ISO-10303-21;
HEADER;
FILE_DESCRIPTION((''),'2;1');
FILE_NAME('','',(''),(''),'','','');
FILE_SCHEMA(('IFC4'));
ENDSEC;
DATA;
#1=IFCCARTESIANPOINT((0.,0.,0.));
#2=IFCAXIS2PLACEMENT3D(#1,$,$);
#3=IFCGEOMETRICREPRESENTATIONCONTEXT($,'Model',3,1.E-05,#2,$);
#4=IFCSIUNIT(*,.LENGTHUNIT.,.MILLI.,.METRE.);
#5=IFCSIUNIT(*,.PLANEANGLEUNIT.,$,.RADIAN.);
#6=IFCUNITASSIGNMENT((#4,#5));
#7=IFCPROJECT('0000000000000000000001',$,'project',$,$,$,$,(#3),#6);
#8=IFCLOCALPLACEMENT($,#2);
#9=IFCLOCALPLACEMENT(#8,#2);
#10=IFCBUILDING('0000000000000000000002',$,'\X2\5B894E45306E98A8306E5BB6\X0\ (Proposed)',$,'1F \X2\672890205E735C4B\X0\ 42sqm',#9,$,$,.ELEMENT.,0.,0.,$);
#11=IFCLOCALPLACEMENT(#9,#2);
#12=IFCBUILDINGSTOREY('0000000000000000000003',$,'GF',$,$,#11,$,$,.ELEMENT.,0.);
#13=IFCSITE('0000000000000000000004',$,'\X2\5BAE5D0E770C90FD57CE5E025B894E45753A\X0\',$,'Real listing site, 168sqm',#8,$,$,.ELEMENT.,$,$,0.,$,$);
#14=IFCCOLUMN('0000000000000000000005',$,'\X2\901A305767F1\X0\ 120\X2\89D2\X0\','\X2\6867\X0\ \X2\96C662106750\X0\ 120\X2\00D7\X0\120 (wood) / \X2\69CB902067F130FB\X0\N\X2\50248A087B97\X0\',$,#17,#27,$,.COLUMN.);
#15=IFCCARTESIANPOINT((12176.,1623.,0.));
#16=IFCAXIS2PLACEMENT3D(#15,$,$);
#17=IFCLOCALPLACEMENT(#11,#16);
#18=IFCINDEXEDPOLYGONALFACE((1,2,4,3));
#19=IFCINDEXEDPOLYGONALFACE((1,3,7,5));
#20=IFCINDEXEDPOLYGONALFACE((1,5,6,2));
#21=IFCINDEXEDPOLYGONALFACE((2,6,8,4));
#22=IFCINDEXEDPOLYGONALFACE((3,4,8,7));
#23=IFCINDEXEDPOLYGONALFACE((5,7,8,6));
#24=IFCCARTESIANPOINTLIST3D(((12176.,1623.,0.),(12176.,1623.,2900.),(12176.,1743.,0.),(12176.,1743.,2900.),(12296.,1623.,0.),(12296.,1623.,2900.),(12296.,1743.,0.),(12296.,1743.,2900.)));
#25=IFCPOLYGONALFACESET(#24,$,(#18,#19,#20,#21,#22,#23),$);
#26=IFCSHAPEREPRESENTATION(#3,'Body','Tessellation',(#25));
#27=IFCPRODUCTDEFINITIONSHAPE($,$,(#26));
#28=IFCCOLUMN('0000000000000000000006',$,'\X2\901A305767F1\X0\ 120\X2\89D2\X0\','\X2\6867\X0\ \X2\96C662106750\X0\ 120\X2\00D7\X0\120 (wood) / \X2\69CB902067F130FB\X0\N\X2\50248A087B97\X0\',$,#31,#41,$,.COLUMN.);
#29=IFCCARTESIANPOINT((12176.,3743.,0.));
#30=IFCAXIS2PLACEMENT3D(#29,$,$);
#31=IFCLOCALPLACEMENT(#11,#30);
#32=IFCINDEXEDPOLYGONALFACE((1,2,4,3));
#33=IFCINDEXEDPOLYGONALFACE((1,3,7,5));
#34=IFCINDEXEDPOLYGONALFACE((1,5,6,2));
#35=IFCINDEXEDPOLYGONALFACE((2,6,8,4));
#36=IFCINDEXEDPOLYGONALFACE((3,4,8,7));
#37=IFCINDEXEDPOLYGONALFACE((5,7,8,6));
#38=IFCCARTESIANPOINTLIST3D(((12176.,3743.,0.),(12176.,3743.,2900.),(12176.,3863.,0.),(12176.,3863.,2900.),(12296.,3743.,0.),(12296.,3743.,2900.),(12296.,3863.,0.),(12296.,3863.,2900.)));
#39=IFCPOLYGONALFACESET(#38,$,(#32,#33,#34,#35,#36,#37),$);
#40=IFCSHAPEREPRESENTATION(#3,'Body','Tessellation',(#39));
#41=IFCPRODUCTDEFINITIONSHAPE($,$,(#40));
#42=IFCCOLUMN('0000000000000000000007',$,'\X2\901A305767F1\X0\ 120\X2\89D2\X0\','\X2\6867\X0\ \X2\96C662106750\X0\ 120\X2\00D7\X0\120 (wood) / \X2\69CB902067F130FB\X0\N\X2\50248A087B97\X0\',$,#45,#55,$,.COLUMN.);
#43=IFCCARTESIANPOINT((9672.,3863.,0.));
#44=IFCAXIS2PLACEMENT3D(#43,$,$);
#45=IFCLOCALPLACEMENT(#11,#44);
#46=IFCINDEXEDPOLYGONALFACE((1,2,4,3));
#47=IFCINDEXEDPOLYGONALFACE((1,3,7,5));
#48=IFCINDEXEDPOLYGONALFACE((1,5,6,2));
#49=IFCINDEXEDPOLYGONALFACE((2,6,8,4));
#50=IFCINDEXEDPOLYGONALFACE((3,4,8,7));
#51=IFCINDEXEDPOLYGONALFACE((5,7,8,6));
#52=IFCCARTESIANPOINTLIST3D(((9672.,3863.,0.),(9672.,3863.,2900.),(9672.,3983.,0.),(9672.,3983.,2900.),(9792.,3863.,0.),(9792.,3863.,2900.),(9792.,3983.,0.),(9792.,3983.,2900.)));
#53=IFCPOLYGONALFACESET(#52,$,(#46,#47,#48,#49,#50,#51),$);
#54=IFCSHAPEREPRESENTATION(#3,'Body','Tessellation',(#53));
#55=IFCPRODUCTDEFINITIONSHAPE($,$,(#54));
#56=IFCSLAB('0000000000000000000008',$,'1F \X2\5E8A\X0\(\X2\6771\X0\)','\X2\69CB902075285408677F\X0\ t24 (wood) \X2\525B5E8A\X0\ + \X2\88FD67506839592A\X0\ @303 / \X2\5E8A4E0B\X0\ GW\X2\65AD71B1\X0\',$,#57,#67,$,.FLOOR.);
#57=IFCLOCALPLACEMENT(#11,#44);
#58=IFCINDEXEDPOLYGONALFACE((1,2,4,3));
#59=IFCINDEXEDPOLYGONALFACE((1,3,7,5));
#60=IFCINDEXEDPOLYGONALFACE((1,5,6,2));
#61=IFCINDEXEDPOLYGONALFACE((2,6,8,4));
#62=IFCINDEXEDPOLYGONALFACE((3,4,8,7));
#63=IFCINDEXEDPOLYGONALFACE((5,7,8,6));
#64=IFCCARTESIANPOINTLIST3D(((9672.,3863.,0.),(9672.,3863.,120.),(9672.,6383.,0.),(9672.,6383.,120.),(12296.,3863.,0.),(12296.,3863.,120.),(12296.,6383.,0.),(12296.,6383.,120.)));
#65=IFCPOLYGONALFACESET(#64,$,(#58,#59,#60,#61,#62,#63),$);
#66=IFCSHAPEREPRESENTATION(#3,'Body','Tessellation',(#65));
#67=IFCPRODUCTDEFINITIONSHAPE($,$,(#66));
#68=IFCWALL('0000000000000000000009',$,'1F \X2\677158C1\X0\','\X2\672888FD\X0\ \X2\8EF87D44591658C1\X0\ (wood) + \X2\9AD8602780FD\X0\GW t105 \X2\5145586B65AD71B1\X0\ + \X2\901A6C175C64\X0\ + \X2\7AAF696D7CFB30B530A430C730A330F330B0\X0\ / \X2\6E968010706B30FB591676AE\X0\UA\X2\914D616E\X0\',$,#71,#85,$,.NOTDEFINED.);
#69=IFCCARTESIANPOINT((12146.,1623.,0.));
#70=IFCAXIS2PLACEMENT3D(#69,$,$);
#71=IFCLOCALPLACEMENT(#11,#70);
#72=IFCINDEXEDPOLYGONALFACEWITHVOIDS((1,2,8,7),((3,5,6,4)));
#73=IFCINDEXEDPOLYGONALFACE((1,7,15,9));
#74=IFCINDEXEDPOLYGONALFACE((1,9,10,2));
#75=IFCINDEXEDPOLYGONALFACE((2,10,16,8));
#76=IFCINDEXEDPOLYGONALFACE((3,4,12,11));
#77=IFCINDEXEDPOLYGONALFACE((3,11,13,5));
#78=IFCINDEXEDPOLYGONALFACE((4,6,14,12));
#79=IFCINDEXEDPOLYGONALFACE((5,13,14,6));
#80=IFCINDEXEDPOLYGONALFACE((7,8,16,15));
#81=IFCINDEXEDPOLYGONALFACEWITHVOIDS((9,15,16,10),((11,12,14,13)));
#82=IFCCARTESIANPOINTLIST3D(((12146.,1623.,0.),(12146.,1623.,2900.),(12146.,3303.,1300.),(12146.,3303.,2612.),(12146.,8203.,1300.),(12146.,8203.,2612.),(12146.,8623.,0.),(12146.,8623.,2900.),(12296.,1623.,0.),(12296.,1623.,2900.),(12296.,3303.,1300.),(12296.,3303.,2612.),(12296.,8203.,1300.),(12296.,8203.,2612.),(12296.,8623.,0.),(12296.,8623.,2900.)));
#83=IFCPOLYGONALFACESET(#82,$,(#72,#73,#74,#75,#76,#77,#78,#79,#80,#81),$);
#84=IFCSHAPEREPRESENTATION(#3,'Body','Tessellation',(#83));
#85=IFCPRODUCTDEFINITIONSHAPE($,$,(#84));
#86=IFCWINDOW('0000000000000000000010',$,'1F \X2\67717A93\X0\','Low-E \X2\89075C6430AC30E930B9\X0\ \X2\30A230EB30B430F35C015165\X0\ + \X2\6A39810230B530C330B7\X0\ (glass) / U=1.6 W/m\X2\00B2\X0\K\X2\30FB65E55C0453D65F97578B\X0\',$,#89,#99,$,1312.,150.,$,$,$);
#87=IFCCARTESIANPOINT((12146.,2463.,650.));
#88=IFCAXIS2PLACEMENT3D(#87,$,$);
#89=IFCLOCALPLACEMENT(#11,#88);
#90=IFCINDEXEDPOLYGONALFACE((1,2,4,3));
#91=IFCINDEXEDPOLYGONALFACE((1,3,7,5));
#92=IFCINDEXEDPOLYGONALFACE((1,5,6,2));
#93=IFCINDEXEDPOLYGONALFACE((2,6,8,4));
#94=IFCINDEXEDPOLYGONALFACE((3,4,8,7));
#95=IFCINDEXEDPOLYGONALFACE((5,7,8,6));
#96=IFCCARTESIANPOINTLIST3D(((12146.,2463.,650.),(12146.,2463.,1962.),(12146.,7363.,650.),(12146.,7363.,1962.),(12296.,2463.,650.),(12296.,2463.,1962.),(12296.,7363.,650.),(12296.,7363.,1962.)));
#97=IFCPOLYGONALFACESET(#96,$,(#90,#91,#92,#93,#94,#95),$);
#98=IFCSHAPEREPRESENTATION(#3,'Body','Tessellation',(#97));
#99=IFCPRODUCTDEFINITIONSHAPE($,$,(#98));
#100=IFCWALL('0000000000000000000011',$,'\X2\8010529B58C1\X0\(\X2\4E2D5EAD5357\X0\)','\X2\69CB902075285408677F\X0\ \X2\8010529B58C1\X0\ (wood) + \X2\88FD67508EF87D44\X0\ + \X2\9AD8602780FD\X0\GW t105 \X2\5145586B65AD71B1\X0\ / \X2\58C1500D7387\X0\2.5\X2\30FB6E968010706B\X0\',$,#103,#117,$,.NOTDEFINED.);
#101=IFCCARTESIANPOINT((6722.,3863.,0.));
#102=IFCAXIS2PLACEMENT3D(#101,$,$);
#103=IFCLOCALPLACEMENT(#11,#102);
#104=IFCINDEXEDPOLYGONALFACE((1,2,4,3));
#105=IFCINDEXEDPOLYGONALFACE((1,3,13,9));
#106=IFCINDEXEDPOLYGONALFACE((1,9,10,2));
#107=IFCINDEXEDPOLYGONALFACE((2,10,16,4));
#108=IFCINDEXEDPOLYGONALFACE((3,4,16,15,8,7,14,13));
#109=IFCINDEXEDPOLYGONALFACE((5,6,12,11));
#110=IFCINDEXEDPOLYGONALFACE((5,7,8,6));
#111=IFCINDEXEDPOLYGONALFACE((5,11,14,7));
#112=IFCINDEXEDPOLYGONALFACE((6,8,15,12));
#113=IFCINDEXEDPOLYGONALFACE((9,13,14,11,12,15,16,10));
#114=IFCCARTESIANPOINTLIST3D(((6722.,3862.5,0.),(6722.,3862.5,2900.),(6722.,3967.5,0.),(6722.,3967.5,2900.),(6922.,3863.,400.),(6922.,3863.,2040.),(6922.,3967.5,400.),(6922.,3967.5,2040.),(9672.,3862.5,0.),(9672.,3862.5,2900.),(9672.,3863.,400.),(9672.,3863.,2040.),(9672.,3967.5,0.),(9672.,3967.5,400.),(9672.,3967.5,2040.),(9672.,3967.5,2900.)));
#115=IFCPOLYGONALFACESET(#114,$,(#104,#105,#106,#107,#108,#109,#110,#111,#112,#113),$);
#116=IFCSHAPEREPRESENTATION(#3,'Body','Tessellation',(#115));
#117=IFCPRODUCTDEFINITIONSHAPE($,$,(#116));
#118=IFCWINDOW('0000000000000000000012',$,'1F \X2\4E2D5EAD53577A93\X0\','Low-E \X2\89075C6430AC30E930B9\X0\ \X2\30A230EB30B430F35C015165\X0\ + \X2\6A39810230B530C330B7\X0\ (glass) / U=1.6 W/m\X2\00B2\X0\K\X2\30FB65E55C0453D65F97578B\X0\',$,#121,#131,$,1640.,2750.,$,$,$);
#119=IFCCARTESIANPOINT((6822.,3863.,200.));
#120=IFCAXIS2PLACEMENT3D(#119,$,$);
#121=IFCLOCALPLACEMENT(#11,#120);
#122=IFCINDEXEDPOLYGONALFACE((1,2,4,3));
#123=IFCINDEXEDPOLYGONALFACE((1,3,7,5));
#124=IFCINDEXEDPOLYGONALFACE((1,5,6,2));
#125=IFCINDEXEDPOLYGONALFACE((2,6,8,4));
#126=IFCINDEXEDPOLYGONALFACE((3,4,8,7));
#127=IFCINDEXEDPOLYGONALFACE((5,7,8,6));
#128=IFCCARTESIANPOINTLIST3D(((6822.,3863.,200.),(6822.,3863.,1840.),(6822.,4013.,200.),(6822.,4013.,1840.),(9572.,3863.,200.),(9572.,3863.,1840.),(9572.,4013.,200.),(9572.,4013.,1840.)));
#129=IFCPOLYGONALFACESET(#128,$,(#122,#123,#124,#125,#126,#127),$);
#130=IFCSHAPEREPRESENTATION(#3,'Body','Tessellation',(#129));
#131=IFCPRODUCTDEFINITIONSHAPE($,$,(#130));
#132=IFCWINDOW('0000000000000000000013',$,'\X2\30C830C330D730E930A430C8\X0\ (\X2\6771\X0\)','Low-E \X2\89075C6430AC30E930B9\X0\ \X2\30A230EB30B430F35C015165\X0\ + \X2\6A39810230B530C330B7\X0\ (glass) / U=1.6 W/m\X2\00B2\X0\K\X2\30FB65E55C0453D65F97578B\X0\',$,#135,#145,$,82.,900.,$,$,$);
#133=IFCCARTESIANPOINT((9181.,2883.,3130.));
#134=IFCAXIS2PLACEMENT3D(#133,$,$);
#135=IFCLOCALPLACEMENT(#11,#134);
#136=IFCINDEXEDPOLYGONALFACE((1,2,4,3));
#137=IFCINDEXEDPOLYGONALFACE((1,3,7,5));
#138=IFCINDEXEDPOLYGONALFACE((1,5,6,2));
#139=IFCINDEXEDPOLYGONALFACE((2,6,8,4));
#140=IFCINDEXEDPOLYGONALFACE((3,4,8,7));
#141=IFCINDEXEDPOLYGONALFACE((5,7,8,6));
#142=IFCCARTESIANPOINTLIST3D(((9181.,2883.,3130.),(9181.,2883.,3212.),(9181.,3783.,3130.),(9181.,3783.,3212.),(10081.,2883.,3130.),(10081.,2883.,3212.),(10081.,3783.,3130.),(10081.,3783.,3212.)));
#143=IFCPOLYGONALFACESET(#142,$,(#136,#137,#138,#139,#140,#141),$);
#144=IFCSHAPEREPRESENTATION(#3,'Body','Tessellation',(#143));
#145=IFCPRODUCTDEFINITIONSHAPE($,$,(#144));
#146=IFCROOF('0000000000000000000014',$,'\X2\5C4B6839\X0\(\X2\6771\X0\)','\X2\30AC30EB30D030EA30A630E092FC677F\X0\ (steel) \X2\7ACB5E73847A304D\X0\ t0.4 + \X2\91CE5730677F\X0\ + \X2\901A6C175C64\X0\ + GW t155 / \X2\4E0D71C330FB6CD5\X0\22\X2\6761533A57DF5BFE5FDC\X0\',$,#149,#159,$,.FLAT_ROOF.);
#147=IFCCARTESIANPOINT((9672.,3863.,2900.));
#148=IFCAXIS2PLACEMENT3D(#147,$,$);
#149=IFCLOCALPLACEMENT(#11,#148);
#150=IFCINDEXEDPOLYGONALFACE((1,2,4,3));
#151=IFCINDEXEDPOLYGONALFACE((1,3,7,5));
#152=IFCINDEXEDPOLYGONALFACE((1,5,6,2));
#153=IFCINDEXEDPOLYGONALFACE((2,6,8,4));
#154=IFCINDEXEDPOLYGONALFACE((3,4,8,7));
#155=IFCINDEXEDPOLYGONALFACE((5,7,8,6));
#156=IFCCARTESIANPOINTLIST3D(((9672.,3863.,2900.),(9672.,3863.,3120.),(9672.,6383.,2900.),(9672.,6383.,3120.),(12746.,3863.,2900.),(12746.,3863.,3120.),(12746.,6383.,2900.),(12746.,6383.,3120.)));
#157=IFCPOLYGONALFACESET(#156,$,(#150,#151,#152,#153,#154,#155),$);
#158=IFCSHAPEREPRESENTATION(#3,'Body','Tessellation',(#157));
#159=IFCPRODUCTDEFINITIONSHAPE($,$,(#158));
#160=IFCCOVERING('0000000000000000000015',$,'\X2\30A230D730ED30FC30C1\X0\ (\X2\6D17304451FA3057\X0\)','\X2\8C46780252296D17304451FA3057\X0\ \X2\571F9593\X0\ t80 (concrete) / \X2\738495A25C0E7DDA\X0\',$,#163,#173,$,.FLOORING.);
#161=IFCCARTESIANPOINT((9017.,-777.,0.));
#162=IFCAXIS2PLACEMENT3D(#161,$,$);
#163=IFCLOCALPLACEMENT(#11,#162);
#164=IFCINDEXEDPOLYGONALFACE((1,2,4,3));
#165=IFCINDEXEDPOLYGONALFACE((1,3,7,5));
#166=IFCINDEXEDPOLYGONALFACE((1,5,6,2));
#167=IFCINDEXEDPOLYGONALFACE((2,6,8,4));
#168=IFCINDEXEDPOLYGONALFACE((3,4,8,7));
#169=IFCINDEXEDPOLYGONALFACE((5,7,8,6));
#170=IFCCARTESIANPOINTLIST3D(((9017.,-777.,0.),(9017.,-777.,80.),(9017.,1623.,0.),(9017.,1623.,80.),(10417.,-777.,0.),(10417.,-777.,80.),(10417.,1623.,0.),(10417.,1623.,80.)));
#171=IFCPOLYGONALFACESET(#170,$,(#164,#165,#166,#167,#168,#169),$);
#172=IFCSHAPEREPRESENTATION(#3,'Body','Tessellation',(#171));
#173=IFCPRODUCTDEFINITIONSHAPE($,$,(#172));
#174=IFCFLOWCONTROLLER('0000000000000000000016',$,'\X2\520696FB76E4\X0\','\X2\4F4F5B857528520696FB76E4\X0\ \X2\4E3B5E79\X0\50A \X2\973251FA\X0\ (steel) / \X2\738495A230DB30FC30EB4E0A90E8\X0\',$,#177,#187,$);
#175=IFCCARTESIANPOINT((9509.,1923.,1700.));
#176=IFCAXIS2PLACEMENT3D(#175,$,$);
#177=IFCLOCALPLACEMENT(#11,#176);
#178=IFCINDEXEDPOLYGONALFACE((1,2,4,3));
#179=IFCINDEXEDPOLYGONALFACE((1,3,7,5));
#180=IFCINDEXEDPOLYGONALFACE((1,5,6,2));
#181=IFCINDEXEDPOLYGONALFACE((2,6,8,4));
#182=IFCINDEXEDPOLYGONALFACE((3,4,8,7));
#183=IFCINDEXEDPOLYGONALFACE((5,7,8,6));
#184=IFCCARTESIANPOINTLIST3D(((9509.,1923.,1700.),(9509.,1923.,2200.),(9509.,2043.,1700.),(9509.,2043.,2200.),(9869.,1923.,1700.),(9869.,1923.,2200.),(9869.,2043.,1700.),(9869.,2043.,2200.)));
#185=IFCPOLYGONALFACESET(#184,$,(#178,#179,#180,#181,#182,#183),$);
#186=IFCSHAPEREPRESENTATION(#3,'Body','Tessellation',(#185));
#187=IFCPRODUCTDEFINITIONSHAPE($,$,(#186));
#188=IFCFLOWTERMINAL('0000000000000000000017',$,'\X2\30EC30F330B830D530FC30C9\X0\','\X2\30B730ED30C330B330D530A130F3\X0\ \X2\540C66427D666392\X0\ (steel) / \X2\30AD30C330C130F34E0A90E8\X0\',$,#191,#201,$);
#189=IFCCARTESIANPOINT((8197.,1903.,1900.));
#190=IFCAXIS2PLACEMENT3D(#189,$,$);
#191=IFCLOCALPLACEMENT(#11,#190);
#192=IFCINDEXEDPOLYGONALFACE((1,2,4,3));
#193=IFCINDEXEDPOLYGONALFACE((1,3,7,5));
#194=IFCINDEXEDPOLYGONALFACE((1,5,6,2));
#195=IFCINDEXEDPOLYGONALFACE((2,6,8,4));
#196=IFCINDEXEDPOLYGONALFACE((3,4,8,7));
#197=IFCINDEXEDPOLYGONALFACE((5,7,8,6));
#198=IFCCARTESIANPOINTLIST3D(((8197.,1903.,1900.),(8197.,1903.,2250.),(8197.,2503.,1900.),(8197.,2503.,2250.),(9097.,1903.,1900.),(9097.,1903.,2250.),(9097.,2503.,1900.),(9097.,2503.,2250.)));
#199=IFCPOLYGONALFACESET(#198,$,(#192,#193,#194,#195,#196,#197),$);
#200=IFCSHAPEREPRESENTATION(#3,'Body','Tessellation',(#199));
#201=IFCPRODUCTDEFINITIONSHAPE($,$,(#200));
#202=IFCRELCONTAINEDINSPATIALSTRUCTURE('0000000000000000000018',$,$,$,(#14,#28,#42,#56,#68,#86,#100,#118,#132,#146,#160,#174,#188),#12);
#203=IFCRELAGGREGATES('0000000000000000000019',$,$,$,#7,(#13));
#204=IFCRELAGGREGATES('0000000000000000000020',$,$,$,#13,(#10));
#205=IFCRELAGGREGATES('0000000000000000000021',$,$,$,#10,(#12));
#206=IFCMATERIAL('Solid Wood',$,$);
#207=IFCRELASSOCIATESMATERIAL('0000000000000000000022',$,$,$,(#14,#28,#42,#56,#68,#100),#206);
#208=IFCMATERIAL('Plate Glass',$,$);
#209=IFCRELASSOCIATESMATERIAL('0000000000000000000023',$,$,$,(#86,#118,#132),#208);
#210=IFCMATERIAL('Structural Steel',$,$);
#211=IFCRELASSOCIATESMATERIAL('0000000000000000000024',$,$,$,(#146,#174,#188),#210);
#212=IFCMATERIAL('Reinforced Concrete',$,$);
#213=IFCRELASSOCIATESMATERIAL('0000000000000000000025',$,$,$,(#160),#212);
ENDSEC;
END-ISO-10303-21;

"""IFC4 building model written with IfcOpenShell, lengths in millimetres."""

from ifc_helpers import new_model, si_unit, frame, frame_2d, origin, place, context, project, spatial, rectangle, extrude, material, element, fill, save


model = new_model("IFC4")

# Units and contexts
model_context = context("Model", 3, precision=1e-05, world=origin())
ifc_project = project(units=[si_unit("LENGTHUNIT", "METRE", prefix="MILLI"), si_unit("PLANEANGLEUNIT", "RADIAN")], contexts=[model_context])

# Site, building, storey
site_placement = place(None, origin())
site = spatial("IfcSite", under=ifc_project, at=site_placement, Name="宮崎県都城市安久町", ObjectType="Real listing site, 168sqm", CompositionType="ELEMENT", RefElevation=0.0)
building_placement = place(site_placement, origin())
building = spatial("IfcBuilding", under=site, at=building_placement, Name="安久の風の家 (Proposed)", ObjectType="1F 木造平屋 42sqm", CompositionType="ELEMENT", ElevationOfRefHeight=0.0, ElevationOfTerrain=0.0)
storey_placement = place(building_placement, origin())
storey = spatial("IfcBuildingStorey", under=building, at=storey_placement, Name="GF", CompositionType="ELEMENT", Elevation=0.0)

# Columns
ifc_material_1 = material(Name="Solid Wood")
column_1_placement = place(storey_placement, frame((12176.0, 1623.0, 0.0)))
element("IfcColumn", 1, at=column_1_placement, inside=storey, material=ifc_material_1, Name="通し柱 120角", Description="桧 集成材 120×120 (wood) / 構造柱・N値計算", PredefinedType="COLUMN", context=model_context, shape_type="SweptSolid", body=[
    extrude(rectangle(XDim=120.0, YDim=120.0, at=frame_2d((60.0, 60.0))), frame((12176.0, 1623.0, 0.0)), (0.0, 0.0, 1.0), 2900.0),
])
column_2_placement = place(storey_placement, frame((12176.0, 3743.0, 0.0)))
element("IfcColumn", 2, at=column_2_placement, inside=storey, material=ifc_material_1, Name="通し柱 120角", Description="桧 集成材 120×120 (wood) / 構造柱・N値計算", PredefinedType="COLUMN", context=model_context, shape_type="SweptSolid", body=[
    extrude(rectangle(XDim=120.0, YDim=120.0, at=frame_2d((60.0, 60.0))), frame((12176.0, 3743.0, 0.0)), (0.0, 0.0, 1.0), 2900.0),
])
column_3_placement = place(storey_placement, frame((9672.0, 3863.0, 0.0)))
element("IfcColumn", 3, at=column_3_placement, inside=storey, material=ifc_material_1, Name="通し柱 120角", Description="桧 集成材 120×120 (wood) / 構造柱・N値計算", PredefinedType="COLUMN", context=model_context, shape_type="SweptSolid", body=[
    extrude(rectangle(XDim=120.0, YDim=120.0, at=frame_2d((60.0, 60.0))), frame((9672.0, 3863.0, 0.0)), (0.0, 0.0, 1.0), 2900.0),
])

# Slab
slab_placement = place(storey_placement, frame((9672.0, 3863.0, 0.0)))
element("IfcSlab", 4, at=slab_placement, inside=storey, material=ifc_material_1, Name="1F 床(東)", Description="構造用合板 t24 (wood) 剛床 + 製材根太 @303 / 床下 GW断熱", PredefinedType="FLOOR", context=model_context, shape_type="SweptSolid", body=[
    extrude(rectangle(XDim=2624.0, YDim=2520.0, at=frame_2d((1312.0, 1260.0))), frame((9672.0, 3863.0, 0.0)), (0.0, 0.0, 1.0), 120.0),
])

# Walls, openings, windows
wall_1_placement = place(storey_placement, frame((12146.0, 1623.0, 0.0)))
wall_1 = element("IfcWall", 5, at=wall_1_placement, inside=storey, material=ifc_material_1, Name="1F 東壁", Description="木製 軸組外壁 (wood) + 高性能GW t105 充填断熱 + 通気層 + 窯業系サイディング / 準耐火・外皮UA配慮", PredefinedType="NOTDEFINED", context=model_context, shape_type="SweptSolid", body=[
    extrude(rectangle(XDim=150.0, YDim=7000.0, at=frame_2d((75.0, 3500.0))), frame((12146.0, 1623.0, 0.0)), (0.0, 0.0, 1.0), 2900.0),
])
opening_1_placement = place(storey_placement, frame((12146.0, 2463.0, 650.0)))
opening_1 = element("IfcOpeningElement", 6, at=opening_1_placement, cuts=wall_1, PredefinedType="NOTDEFINED", context=model_context, shape_type="SweptSolid", body=[
    extrude(rectangle(XDim=150.0, YDim=4900.0, at=frame_2d((75.0, 2450.0))), frame((12146.0, 2463.0, 650.0)), (0.0, 0.0, 1.0), 1312.0),
])
ifc_material_2 = material(Name="Plate Glass")
window_1_placement = place(storey_placement, frame((12146.0, 2463.0, 650.0)))
window_1 = element("IfcWindow", 7, at=window_1_placement, inside=storey, material=ifc_material_2, Name="1F 東窓", Description="Low-E 複層ガラス アルゴン封入 + 樹脂サッシ (glass) / U=1.6 W/m²K・日射取得型", OverallHeight=1312.0, OverallWidth=150.0, context=model_context, shape_type="SweptSolid", body=[
    extrude(rectangle(XDim=150.0, YDim=4900.0, at=frame_2d((75.0, 2450.0))), frame((12146.0, 2463.0, 650.0)), (0.0, 0.0, 1.0), 1312.0),
])
fill(opening_1, window_1)
wall_2_placement = place(storey_placement, frame((6722.0, 3863.0, 0.0)))
wall_2 = element("IfcWall", 8, at=wall_2_placement, inside=storey, material=ifc_material_1, Name="耐力壁(中庭南)", Description="構造用合板 耐力壁 (wood) + 製材軸組 + 高性能GW t105 充填断熱 / 壁倍率2.5・準耐火", PredefinedType="NOTDEFINED", context=model_context, shape_type="SweptSolid", body=[
    extrude(rectangle(XDim=2950.0, YDim=105.0, at=frame_2d((1475.0, 52.0))), frame((6722.0, 3863.0, 0.0)), (0.0, 0.0, 1.0), 2900.0),
])
opening_2_placement = place(storey_placement, frame((6822.0, 3863.0, 200.0)))
opening_2 = element("IfcOpeningElement", 9, at=opening_2_placement, cuts=wall_2, PredefinedType="NOTDEFINED", context=model_context, shape_type="SweptSolid", body=[
    extrude(rectangle(XDim=2750.0, YDim=150.0, at=frame_2d((1375.0, 75.0))), frame((6822.0, 3863.0, 200.0)), (0.0, 0.0, 1.0), 1640.0),
])
window_2_placement = place(storey_placement, frame((6822.0, 3863.0, 200.0)))
window_2 = element("IfcWindow", 10, at=window_2_placement, inside=storey, material=ifc_material_2, Name="1F 中庭南窓", Description="Low-E 複層ガラス アルゴン封入 + 樹脂サッシ (glass) / U=1.6 W/m²K・日射取得型", OverallHeight=1640.0, OverallWidth=2750.0, context=model_context, shape_type="SweptSolid", body=[
    extrude(rectangle(XDim=2750.0, YDim=150.0, at=frame_2d((1375.0, 75.0))), frame((6822.0, 3863.0, 200.0)), (0.0, 0.0, 1.0), 1640.0),
])
fill(opening_2, window_2)

# Window
window_3_placement = place(storey_placement, frame((9181.0, 2883.0, 3130.0)))
element("IfcWindow", 11, at=window_3_placement, inside=storey, material=ifc_material_2, Name="トップライト (東)", Description="Low-E 複層ガラス アルゴン封入 + 樹脂サッシ (glass) / U=1.6 W/m²K・日射取得型", OverallHeight=82.0, OverallWidth=900.0, context=model_context, shape_type="SweptSolid", body=[
    extrude(rectangle(XDim=900.0, YDim=900.0, at=frame_2d((450.0, 450.0))), frame((9181.0, 2883.0, 3130.0)), (0.0, 0.0, 1.0), 82.0),
])

# Roof
ifc_material_3 = material(Name="Structural Steel")
roof_placement = place(storey_placement, frame((9672.0, 3863.0, 2900.0)))
element("IfcRoof", 12, at=roof_placement, inside=storey, material=ifc_material_3, Name="屋根(東)", Description="ガルバリウム鋼板 (steel) 立平葺き t0.4 + 野地板 + 通気層 + GW t155 / 不燃・法22条区域対応", PredefinedType="FLAT_ROOF", context=model_context, shape_type="SweptSolid", body=[
    extrude(rectangle(XDim=3074.0, YDim=2520.0, at=frame_2d((1537.0, 1260.0))), frame((9672.0, 3863.0, 2900.0)), (0.0, 0.0, 1.0), 220.0),
])

# Covering
ifc_material_4 = material(Name="Reinforced Concrete")
covering_placement = place(storey_placement, frame((9017.0, -777.0, 0.0)))
element("IfcCovering", 13, at=covering_placement, inside=storey, material=ifc_material_4, Name="アプローチ (洗い出し)", Description="豆砂利洗い出し 土間 t80 (concrete) / 玄関導線", PredefinedType="FLOORING", context=model_context, shape_type="SweptSolid", body=[
    extrude(rectangle(XDim=1400.0, YDim=2400.0, at=frame_2d((700.0, 1200.0))), frame((9017.0, -777.0, 0.0)), (0.0, 0.0, 1.0), 80.0),
])

# Flow controller
flow_controller_placement = place(storey_placement, frame((9509.0, 1923.0, 1700.0)))
element("IfcFlowController", 14, at=flow_controller_placement, inside=storey, material=ifc_material_3, Name="分電盤", Description="住宅用分電盤 主幹50A 露出 (steel) / 玄関ホール上部", context=model_context, shape_type="SweptSolid", body=[
    extrude(rectangle(XDim=360.0, YDim=120.0, at=frame_2d((180.0, 60.0))), frame((9509.0, 1923.0, 1700.0)), (0.0, 0.0, 1.0), 500.0),
])

# Flow terminal
flow_terminal_1_placement = place(storey_placement, frame((8197.0, 1903.0, 1900.0)))
element("IfcFlowTerminal", 15, at=flow_terminal_1_placement, inside=storey, material=ifc_material_3, Name="レンジフード", Description="シロッコファン 同時給排 (steel) / キッチン上部", context=model_context, shape_type="SweptSolid", body=[
    extrude(rectangle(XDim=900.0, YDim=600.0, at=frame_2d((450.0, 300.0))), frame((8197.0, 1903.0, 1900.0)), (0.0, 0.0, 1.0), 350.0),
])

save(model, "model.ifc")
